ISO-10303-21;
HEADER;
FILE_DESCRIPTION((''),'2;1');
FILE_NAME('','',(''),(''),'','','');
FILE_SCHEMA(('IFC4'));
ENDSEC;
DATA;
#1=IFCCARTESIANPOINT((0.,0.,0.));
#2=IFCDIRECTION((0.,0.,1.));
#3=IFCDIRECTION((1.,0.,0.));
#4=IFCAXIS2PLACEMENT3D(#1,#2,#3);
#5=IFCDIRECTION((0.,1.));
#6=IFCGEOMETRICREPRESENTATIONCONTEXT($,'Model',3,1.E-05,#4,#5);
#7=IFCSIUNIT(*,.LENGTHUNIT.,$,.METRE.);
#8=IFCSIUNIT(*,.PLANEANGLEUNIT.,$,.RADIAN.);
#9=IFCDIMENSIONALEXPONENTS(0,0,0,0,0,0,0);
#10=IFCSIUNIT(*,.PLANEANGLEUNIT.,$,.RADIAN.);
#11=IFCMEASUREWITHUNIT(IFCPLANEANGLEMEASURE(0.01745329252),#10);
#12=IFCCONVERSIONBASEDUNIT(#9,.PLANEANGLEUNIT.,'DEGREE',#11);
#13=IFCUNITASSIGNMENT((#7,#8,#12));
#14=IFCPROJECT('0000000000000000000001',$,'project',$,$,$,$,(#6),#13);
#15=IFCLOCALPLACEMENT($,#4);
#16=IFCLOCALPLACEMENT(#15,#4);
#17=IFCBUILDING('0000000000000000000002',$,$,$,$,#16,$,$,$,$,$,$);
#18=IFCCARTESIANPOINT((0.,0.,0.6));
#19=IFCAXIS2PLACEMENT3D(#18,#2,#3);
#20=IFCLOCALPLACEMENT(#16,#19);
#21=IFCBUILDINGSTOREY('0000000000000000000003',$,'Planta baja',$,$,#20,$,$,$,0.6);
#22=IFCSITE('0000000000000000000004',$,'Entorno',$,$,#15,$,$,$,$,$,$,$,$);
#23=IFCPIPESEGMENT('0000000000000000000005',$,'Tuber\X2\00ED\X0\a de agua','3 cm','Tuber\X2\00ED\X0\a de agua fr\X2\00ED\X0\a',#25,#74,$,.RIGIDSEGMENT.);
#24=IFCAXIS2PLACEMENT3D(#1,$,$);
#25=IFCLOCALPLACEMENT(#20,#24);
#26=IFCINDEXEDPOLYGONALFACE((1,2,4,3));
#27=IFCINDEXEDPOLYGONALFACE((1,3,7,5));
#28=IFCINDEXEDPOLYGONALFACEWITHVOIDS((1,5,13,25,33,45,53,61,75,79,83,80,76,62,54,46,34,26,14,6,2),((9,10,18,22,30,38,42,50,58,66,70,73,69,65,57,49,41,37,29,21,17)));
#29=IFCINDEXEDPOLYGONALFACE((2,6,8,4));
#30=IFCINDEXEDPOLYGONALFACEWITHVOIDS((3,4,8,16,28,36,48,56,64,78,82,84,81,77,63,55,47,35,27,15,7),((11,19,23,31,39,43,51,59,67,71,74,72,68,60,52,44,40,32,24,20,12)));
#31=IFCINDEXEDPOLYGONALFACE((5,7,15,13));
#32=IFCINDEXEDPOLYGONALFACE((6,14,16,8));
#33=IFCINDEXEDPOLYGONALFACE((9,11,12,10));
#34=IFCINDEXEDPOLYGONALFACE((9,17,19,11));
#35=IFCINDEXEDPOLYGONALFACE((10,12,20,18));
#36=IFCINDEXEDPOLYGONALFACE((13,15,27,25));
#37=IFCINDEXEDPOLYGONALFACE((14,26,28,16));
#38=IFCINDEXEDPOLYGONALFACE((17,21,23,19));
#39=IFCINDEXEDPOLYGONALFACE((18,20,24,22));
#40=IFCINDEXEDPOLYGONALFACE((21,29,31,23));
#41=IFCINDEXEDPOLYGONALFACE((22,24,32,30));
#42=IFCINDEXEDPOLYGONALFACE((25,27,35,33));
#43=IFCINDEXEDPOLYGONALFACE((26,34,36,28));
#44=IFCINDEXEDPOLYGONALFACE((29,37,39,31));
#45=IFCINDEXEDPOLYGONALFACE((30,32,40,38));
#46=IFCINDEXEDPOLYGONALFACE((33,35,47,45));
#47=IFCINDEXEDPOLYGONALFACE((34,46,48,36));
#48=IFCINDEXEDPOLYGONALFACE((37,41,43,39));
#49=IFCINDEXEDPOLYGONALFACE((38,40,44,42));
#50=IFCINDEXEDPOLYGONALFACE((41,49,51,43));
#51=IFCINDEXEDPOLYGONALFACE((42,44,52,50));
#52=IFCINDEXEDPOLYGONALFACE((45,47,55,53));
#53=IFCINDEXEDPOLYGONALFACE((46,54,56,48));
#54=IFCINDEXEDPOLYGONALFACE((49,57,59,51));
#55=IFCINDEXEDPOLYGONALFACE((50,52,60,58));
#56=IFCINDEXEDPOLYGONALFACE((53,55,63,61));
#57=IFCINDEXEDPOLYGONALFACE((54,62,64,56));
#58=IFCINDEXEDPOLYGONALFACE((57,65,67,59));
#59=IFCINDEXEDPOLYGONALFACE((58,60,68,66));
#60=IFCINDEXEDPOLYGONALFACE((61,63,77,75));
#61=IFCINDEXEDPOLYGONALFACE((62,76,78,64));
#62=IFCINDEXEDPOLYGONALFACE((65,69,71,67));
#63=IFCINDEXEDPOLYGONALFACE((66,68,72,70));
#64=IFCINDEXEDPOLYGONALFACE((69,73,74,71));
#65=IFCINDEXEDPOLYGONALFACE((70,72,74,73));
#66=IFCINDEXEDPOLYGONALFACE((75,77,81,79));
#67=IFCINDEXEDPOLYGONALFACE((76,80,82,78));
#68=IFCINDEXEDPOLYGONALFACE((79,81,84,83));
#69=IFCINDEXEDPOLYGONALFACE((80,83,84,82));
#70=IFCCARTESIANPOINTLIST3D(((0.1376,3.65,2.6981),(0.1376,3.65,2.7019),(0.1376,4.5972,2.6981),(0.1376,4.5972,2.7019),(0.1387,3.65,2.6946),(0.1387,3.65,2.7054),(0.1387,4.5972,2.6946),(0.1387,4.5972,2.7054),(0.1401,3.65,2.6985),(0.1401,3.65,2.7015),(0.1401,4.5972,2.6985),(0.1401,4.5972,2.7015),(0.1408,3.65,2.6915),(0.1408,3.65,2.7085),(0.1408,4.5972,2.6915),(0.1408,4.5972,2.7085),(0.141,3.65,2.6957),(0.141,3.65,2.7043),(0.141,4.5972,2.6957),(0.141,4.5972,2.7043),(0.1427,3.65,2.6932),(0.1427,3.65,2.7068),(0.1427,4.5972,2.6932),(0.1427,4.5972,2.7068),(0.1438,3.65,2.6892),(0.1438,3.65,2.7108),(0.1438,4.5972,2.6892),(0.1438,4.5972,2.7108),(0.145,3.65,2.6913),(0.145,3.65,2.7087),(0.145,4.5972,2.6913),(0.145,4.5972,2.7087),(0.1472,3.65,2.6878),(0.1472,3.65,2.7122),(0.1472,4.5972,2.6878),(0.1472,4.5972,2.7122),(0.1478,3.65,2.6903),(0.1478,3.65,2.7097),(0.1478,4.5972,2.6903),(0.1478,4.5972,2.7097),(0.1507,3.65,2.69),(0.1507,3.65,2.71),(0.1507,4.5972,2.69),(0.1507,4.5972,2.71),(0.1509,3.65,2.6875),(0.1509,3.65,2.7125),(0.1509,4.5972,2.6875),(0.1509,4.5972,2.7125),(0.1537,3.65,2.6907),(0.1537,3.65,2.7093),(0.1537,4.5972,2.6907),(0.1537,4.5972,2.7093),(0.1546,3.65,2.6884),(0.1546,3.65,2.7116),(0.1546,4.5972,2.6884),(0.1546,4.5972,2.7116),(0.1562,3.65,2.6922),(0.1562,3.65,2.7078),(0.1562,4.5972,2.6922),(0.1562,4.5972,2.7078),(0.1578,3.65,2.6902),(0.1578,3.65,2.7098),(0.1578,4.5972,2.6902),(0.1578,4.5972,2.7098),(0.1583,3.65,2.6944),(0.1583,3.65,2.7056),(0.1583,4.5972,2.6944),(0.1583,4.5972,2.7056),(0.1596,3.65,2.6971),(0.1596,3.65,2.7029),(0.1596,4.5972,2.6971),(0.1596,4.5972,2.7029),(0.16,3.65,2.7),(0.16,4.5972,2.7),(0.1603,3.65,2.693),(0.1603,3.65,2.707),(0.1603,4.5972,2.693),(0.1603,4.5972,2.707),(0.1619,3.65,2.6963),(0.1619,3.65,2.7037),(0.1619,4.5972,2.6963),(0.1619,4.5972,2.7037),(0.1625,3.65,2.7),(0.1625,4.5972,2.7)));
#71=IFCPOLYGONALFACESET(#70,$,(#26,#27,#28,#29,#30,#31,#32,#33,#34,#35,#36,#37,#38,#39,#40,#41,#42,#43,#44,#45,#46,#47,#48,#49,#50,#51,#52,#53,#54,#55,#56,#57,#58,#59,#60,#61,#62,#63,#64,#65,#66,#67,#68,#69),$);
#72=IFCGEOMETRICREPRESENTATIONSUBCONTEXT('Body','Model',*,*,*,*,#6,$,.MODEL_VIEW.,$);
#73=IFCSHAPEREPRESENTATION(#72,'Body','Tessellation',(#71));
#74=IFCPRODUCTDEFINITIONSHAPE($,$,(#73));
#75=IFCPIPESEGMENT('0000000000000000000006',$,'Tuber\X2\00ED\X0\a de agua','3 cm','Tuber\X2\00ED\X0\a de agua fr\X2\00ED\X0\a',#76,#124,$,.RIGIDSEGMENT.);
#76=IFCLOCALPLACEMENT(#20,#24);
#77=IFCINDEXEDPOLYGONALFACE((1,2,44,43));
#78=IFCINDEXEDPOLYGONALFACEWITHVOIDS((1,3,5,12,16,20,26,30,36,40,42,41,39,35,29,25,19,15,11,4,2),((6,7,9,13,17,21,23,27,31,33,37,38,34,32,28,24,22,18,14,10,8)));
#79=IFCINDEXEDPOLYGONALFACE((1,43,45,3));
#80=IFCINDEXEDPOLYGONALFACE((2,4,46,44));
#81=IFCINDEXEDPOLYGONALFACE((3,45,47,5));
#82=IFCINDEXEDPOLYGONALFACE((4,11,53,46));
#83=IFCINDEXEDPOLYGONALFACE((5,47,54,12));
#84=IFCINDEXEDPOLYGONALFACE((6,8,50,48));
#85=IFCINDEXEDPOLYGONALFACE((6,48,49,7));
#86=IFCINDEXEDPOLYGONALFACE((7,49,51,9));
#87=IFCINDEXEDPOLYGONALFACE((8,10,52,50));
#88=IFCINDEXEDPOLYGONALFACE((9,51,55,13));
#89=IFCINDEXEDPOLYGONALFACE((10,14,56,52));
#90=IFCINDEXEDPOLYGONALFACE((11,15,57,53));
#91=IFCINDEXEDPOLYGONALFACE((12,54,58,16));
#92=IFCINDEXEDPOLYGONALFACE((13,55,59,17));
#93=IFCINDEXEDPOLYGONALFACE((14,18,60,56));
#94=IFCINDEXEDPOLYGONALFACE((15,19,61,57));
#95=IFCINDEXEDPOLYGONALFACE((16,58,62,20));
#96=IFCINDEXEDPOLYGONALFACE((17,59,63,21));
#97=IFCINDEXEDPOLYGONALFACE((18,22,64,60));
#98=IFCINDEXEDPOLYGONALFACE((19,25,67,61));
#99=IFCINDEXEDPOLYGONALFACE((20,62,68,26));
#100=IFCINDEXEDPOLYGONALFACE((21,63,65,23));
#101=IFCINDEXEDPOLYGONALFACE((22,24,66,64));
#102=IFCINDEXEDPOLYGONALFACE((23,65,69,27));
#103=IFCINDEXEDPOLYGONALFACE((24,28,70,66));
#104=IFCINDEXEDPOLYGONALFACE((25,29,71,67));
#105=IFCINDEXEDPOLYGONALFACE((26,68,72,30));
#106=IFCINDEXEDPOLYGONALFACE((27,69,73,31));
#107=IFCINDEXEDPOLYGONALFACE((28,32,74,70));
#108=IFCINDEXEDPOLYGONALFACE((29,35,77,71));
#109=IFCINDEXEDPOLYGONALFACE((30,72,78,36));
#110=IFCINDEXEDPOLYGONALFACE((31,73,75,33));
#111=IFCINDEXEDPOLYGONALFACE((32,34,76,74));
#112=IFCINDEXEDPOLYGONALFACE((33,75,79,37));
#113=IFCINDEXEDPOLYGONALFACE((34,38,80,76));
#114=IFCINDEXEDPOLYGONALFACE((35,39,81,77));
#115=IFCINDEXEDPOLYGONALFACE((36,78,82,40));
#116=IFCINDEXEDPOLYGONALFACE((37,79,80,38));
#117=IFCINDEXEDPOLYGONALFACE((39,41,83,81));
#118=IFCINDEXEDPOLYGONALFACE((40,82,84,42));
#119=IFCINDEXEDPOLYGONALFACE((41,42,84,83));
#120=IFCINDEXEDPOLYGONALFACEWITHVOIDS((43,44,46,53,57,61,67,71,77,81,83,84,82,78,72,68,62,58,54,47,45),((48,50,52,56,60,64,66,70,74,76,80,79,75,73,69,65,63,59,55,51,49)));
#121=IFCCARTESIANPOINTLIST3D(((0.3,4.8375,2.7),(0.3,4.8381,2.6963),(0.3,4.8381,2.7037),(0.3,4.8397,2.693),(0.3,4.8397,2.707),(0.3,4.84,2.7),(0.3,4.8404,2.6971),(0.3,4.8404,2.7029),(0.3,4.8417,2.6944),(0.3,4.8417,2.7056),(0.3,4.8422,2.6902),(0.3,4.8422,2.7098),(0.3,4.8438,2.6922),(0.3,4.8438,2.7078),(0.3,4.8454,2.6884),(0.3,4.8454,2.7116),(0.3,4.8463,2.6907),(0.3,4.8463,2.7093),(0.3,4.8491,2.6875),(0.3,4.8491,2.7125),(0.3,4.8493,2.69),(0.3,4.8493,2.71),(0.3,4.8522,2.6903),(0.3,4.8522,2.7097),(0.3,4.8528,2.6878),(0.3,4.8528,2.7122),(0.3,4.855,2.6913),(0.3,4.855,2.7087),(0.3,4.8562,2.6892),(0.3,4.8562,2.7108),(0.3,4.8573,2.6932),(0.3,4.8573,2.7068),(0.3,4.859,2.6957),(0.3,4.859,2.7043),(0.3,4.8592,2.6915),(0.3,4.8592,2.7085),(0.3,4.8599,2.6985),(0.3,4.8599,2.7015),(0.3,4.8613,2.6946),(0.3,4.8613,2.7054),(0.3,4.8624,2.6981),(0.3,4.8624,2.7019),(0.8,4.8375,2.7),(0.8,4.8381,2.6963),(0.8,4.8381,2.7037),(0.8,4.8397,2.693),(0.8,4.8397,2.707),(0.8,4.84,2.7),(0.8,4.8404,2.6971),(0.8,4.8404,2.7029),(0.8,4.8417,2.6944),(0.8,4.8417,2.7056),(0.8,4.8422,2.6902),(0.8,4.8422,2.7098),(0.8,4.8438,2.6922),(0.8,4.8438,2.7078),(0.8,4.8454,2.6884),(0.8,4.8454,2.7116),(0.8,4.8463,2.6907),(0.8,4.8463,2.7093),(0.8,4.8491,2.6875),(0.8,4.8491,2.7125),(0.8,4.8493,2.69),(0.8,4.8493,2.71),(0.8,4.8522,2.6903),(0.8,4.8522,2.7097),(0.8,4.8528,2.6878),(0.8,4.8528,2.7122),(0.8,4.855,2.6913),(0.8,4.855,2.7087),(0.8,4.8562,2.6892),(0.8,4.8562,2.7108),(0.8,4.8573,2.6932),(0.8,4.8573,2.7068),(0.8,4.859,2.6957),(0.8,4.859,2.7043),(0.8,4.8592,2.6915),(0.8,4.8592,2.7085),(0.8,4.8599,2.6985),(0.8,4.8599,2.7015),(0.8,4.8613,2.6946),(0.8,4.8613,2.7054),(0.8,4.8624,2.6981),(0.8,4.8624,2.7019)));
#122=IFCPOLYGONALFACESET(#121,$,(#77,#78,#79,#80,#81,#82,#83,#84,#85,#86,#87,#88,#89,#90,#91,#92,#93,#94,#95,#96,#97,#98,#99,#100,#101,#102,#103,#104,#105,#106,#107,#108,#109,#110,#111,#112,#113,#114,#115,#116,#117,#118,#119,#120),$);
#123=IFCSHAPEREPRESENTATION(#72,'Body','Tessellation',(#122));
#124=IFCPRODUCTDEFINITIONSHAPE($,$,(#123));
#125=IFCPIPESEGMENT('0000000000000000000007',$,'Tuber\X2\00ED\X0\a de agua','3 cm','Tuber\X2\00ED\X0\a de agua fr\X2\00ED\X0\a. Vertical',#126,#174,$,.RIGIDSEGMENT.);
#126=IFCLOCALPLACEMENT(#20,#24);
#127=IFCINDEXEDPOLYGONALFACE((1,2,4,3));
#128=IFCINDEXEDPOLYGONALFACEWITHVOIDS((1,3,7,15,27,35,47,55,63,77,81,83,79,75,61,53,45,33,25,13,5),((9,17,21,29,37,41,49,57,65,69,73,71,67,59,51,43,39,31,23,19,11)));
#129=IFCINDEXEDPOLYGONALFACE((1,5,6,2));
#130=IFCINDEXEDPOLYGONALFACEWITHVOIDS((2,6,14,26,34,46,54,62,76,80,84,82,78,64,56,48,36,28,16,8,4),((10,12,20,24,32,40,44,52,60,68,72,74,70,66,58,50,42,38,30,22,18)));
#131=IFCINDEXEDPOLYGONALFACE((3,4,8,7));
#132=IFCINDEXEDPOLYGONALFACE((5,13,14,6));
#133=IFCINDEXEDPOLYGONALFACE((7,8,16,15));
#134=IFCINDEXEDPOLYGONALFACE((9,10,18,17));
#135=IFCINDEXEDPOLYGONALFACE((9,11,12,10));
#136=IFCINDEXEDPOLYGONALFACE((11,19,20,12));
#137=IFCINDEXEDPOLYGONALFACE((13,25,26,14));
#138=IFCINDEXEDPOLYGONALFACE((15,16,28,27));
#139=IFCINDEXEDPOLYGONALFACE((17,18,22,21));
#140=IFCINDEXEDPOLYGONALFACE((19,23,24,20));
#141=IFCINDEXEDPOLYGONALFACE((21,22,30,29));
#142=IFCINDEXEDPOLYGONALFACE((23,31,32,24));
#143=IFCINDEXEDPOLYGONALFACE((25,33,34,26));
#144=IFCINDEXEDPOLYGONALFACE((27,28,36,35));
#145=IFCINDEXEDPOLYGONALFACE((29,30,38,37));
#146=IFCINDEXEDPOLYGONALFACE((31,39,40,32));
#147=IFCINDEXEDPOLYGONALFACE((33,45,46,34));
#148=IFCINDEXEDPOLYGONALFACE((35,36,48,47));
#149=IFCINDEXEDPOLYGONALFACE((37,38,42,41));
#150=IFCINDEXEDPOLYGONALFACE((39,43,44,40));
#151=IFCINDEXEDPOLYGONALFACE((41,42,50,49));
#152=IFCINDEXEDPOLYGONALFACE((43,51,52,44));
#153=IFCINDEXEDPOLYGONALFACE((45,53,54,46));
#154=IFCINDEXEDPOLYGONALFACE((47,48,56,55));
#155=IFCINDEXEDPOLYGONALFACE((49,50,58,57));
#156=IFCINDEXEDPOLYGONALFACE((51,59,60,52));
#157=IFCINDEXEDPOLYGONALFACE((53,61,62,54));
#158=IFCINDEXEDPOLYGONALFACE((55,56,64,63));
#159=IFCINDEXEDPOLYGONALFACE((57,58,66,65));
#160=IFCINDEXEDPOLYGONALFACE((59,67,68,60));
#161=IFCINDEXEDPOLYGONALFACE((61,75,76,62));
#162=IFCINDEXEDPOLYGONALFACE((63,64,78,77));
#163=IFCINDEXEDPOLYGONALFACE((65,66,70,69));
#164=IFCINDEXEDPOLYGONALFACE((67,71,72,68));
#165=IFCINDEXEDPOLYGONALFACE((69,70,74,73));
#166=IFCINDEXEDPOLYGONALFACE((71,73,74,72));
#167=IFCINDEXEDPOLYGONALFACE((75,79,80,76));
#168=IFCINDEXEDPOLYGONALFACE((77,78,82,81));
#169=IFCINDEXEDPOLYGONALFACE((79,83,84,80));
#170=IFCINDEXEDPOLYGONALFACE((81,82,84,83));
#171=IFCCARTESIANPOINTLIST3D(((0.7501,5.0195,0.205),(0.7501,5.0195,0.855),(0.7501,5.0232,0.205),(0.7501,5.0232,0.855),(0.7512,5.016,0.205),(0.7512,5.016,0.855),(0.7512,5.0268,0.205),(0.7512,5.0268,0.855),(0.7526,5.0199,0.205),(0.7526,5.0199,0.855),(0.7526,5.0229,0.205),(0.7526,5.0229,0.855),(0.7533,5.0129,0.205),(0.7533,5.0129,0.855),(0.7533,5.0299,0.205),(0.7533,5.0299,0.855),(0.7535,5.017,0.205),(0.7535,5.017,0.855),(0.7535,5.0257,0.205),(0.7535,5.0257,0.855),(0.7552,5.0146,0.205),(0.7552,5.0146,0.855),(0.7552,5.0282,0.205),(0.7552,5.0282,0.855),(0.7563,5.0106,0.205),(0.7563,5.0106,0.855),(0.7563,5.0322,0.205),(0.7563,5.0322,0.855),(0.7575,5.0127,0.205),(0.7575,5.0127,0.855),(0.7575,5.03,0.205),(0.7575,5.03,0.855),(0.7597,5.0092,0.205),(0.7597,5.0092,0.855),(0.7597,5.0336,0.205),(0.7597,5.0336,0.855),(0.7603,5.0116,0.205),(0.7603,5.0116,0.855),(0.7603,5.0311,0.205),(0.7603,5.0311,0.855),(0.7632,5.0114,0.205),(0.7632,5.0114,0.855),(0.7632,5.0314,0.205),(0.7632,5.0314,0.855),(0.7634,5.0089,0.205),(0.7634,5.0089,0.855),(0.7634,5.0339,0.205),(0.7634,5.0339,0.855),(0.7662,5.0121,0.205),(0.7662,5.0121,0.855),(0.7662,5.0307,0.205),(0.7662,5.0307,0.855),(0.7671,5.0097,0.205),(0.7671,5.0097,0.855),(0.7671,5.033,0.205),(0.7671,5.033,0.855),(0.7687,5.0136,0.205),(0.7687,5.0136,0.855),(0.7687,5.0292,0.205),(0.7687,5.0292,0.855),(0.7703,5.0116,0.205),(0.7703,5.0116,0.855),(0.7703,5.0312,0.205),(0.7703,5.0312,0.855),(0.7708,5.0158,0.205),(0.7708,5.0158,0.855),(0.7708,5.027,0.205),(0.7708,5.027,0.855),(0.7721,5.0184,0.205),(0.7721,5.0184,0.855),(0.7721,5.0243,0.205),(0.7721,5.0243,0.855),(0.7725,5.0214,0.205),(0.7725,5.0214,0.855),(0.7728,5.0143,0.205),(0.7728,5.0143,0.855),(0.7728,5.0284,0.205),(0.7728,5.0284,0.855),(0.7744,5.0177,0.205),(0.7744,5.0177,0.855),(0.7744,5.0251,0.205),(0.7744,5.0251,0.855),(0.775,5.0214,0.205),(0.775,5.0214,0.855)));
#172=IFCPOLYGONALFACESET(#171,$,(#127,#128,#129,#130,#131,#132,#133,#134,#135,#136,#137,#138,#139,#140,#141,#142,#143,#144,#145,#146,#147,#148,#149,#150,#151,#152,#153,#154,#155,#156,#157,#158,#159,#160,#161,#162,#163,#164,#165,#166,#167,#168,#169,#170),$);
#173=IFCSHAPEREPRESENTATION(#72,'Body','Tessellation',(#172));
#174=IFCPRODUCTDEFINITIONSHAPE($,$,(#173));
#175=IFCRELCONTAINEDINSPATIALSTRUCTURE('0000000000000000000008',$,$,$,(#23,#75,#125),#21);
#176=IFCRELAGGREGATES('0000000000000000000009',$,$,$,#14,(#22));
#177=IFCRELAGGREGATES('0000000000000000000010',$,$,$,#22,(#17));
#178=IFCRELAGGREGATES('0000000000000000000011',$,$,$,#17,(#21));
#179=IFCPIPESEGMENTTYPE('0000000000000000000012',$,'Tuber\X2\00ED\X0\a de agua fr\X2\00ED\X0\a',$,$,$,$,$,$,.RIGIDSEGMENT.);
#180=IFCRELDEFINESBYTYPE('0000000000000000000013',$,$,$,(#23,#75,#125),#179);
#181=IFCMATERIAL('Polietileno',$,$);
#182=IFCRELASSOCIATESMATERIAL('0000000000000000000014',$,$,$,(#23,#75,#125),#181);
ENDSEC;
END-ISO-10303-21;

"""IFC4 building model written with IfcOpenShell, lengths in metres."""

from ifc_helpers import new_model, entity, si_unit, converted_unit, direction, frame, origin_with_axes, origin_2d_with_axis, place, context, subcontext, project, spatial, hollow_circle, extrude, material, type_object, element, save


model = new_model("IFC4")

# Units and contexts
model_context = context("Model", 3, precision=1e-05, world=origin_with_axes(), true_north=direction((0.0, 1.0)))
body_context = subcontext(model_context, "Body", "Model", "MODEL_VIEW")
ifc_project = project(units=[si_unit("LENGTHUNIT", "METRE"), si_unit("PLANEANGLEUNIT", "RADIAN"), converted_unit("PLANEANGLEUNIT", "DEGREE", entity("IfcPlaneAngleMeasure", 0.01745329252), si_unit("PLANEANGLEUNIT", "RADIAN"), dimensions=[0, 0, 0, 0, 0, 0, 0])], contexts=[model_context])

# Site, building, storey
site_placement = place(None, origin_with_axes())
site = spatial("IfcSite", under=ifc_project, at=site_placement, Name="Entorno")
building_placement = place(site_placement, origin_with_axes())
building = spatial("IfcBuilding", under=site, at=building_placement)
storey_placement = place(building_placement, frame((0.0, 0.0, 0.6), z_axis=(0.0, 0.0, 1.0), x_axis=(1.0, 0.0, 0.0)))
storey = spatial("IfcBuildingStorey", under=building, at=storey_placement, Name="Planta baja", Elevation=0.6)

# Pipe segments
ifc_material_1 = material(Name="Polietileno")
pipe_segment_type_1 = type_object("IfcPipeSegmentType", Name="Tubería de agua fría", PredefinedType="RIGIDSEGMENT")
pipe_segment_1_placement = place(storey_placement, frame((0.15, 4.5972, 2.7), z_axis=(0.0, -1.0, 0.0), x_axis=(1.0, 0.0, 0.0)))
element("IfcPipeSegment", 1, at=pipe_segment_1_placement, inside=storey, type_object=pipe_segment_type_1, material=ifc_material_1, Name="Tubería de agua", Description="3 cm", ObjectType="Tubería de agua fría", PredefinedType="RIGIDSEGMENT", context=body_context, shape_type="SweptSolid", body=[
    extrude(hollow_circle(Radius=0.0125, WallThickness=0.0025, at=origin_2d_with_axis()), origin_with_axes(), (0.0, 0.0, 1.0), 0.9472),
])
pipe_segment_2_placement = place(storey_placement, frame((0.8, 4.85, 2.7), z_axis=(-1.0, 0.0, 0.0), x_axis=(0.0, -1.0, 0.0)))
element("IfcPipeSegment", 2, at=pipe_segment_2_placement, inside=storey, type_object=pipe_segment_type_1, material=ifc_material_1, Name="Tubería de agua", Description="3 cm", ObjectType="Tubería de agua fría", PredefinedType="RIGIDSEGMENT", context=body_context, shape_type="SweptSolid", body=[
    extrude(hollow_circle(Radius=0.0125, WallThickness=0.0025, at=origin_2d_with_axis()), origin_with_axes(), (0.0, 0.0, 1.0), 0.5),
])
pipe_segment_3_placement = place(storey_placement, frame((0.7625, 5.0214, 0.205), z_axis=(0.0, 0.0, 1.0), x_axis=(1.0, 0.0, 0.0)))
element("IfcPipeSegment", 3, at=pipe_segment_3_placement, inside=storey, type_object=pipe_segment_type_1, material=ifc_material_1, Name="Tubería de agua", Description="3 cm", ObjectType="Tubería de agua fría. Vertical", PredefinedType="RIGIDSEGMENT", context=body_context, shape_type="SweptSolid", body=[
    extrude(hollow_circle(Radius=0.0125, WallThickness=0.0025, at=origin_2d_with_axis()), origin_with_axes(), (0.0, 0.0, 1.0), 0.65),
])

save(model, "model.ifc")
